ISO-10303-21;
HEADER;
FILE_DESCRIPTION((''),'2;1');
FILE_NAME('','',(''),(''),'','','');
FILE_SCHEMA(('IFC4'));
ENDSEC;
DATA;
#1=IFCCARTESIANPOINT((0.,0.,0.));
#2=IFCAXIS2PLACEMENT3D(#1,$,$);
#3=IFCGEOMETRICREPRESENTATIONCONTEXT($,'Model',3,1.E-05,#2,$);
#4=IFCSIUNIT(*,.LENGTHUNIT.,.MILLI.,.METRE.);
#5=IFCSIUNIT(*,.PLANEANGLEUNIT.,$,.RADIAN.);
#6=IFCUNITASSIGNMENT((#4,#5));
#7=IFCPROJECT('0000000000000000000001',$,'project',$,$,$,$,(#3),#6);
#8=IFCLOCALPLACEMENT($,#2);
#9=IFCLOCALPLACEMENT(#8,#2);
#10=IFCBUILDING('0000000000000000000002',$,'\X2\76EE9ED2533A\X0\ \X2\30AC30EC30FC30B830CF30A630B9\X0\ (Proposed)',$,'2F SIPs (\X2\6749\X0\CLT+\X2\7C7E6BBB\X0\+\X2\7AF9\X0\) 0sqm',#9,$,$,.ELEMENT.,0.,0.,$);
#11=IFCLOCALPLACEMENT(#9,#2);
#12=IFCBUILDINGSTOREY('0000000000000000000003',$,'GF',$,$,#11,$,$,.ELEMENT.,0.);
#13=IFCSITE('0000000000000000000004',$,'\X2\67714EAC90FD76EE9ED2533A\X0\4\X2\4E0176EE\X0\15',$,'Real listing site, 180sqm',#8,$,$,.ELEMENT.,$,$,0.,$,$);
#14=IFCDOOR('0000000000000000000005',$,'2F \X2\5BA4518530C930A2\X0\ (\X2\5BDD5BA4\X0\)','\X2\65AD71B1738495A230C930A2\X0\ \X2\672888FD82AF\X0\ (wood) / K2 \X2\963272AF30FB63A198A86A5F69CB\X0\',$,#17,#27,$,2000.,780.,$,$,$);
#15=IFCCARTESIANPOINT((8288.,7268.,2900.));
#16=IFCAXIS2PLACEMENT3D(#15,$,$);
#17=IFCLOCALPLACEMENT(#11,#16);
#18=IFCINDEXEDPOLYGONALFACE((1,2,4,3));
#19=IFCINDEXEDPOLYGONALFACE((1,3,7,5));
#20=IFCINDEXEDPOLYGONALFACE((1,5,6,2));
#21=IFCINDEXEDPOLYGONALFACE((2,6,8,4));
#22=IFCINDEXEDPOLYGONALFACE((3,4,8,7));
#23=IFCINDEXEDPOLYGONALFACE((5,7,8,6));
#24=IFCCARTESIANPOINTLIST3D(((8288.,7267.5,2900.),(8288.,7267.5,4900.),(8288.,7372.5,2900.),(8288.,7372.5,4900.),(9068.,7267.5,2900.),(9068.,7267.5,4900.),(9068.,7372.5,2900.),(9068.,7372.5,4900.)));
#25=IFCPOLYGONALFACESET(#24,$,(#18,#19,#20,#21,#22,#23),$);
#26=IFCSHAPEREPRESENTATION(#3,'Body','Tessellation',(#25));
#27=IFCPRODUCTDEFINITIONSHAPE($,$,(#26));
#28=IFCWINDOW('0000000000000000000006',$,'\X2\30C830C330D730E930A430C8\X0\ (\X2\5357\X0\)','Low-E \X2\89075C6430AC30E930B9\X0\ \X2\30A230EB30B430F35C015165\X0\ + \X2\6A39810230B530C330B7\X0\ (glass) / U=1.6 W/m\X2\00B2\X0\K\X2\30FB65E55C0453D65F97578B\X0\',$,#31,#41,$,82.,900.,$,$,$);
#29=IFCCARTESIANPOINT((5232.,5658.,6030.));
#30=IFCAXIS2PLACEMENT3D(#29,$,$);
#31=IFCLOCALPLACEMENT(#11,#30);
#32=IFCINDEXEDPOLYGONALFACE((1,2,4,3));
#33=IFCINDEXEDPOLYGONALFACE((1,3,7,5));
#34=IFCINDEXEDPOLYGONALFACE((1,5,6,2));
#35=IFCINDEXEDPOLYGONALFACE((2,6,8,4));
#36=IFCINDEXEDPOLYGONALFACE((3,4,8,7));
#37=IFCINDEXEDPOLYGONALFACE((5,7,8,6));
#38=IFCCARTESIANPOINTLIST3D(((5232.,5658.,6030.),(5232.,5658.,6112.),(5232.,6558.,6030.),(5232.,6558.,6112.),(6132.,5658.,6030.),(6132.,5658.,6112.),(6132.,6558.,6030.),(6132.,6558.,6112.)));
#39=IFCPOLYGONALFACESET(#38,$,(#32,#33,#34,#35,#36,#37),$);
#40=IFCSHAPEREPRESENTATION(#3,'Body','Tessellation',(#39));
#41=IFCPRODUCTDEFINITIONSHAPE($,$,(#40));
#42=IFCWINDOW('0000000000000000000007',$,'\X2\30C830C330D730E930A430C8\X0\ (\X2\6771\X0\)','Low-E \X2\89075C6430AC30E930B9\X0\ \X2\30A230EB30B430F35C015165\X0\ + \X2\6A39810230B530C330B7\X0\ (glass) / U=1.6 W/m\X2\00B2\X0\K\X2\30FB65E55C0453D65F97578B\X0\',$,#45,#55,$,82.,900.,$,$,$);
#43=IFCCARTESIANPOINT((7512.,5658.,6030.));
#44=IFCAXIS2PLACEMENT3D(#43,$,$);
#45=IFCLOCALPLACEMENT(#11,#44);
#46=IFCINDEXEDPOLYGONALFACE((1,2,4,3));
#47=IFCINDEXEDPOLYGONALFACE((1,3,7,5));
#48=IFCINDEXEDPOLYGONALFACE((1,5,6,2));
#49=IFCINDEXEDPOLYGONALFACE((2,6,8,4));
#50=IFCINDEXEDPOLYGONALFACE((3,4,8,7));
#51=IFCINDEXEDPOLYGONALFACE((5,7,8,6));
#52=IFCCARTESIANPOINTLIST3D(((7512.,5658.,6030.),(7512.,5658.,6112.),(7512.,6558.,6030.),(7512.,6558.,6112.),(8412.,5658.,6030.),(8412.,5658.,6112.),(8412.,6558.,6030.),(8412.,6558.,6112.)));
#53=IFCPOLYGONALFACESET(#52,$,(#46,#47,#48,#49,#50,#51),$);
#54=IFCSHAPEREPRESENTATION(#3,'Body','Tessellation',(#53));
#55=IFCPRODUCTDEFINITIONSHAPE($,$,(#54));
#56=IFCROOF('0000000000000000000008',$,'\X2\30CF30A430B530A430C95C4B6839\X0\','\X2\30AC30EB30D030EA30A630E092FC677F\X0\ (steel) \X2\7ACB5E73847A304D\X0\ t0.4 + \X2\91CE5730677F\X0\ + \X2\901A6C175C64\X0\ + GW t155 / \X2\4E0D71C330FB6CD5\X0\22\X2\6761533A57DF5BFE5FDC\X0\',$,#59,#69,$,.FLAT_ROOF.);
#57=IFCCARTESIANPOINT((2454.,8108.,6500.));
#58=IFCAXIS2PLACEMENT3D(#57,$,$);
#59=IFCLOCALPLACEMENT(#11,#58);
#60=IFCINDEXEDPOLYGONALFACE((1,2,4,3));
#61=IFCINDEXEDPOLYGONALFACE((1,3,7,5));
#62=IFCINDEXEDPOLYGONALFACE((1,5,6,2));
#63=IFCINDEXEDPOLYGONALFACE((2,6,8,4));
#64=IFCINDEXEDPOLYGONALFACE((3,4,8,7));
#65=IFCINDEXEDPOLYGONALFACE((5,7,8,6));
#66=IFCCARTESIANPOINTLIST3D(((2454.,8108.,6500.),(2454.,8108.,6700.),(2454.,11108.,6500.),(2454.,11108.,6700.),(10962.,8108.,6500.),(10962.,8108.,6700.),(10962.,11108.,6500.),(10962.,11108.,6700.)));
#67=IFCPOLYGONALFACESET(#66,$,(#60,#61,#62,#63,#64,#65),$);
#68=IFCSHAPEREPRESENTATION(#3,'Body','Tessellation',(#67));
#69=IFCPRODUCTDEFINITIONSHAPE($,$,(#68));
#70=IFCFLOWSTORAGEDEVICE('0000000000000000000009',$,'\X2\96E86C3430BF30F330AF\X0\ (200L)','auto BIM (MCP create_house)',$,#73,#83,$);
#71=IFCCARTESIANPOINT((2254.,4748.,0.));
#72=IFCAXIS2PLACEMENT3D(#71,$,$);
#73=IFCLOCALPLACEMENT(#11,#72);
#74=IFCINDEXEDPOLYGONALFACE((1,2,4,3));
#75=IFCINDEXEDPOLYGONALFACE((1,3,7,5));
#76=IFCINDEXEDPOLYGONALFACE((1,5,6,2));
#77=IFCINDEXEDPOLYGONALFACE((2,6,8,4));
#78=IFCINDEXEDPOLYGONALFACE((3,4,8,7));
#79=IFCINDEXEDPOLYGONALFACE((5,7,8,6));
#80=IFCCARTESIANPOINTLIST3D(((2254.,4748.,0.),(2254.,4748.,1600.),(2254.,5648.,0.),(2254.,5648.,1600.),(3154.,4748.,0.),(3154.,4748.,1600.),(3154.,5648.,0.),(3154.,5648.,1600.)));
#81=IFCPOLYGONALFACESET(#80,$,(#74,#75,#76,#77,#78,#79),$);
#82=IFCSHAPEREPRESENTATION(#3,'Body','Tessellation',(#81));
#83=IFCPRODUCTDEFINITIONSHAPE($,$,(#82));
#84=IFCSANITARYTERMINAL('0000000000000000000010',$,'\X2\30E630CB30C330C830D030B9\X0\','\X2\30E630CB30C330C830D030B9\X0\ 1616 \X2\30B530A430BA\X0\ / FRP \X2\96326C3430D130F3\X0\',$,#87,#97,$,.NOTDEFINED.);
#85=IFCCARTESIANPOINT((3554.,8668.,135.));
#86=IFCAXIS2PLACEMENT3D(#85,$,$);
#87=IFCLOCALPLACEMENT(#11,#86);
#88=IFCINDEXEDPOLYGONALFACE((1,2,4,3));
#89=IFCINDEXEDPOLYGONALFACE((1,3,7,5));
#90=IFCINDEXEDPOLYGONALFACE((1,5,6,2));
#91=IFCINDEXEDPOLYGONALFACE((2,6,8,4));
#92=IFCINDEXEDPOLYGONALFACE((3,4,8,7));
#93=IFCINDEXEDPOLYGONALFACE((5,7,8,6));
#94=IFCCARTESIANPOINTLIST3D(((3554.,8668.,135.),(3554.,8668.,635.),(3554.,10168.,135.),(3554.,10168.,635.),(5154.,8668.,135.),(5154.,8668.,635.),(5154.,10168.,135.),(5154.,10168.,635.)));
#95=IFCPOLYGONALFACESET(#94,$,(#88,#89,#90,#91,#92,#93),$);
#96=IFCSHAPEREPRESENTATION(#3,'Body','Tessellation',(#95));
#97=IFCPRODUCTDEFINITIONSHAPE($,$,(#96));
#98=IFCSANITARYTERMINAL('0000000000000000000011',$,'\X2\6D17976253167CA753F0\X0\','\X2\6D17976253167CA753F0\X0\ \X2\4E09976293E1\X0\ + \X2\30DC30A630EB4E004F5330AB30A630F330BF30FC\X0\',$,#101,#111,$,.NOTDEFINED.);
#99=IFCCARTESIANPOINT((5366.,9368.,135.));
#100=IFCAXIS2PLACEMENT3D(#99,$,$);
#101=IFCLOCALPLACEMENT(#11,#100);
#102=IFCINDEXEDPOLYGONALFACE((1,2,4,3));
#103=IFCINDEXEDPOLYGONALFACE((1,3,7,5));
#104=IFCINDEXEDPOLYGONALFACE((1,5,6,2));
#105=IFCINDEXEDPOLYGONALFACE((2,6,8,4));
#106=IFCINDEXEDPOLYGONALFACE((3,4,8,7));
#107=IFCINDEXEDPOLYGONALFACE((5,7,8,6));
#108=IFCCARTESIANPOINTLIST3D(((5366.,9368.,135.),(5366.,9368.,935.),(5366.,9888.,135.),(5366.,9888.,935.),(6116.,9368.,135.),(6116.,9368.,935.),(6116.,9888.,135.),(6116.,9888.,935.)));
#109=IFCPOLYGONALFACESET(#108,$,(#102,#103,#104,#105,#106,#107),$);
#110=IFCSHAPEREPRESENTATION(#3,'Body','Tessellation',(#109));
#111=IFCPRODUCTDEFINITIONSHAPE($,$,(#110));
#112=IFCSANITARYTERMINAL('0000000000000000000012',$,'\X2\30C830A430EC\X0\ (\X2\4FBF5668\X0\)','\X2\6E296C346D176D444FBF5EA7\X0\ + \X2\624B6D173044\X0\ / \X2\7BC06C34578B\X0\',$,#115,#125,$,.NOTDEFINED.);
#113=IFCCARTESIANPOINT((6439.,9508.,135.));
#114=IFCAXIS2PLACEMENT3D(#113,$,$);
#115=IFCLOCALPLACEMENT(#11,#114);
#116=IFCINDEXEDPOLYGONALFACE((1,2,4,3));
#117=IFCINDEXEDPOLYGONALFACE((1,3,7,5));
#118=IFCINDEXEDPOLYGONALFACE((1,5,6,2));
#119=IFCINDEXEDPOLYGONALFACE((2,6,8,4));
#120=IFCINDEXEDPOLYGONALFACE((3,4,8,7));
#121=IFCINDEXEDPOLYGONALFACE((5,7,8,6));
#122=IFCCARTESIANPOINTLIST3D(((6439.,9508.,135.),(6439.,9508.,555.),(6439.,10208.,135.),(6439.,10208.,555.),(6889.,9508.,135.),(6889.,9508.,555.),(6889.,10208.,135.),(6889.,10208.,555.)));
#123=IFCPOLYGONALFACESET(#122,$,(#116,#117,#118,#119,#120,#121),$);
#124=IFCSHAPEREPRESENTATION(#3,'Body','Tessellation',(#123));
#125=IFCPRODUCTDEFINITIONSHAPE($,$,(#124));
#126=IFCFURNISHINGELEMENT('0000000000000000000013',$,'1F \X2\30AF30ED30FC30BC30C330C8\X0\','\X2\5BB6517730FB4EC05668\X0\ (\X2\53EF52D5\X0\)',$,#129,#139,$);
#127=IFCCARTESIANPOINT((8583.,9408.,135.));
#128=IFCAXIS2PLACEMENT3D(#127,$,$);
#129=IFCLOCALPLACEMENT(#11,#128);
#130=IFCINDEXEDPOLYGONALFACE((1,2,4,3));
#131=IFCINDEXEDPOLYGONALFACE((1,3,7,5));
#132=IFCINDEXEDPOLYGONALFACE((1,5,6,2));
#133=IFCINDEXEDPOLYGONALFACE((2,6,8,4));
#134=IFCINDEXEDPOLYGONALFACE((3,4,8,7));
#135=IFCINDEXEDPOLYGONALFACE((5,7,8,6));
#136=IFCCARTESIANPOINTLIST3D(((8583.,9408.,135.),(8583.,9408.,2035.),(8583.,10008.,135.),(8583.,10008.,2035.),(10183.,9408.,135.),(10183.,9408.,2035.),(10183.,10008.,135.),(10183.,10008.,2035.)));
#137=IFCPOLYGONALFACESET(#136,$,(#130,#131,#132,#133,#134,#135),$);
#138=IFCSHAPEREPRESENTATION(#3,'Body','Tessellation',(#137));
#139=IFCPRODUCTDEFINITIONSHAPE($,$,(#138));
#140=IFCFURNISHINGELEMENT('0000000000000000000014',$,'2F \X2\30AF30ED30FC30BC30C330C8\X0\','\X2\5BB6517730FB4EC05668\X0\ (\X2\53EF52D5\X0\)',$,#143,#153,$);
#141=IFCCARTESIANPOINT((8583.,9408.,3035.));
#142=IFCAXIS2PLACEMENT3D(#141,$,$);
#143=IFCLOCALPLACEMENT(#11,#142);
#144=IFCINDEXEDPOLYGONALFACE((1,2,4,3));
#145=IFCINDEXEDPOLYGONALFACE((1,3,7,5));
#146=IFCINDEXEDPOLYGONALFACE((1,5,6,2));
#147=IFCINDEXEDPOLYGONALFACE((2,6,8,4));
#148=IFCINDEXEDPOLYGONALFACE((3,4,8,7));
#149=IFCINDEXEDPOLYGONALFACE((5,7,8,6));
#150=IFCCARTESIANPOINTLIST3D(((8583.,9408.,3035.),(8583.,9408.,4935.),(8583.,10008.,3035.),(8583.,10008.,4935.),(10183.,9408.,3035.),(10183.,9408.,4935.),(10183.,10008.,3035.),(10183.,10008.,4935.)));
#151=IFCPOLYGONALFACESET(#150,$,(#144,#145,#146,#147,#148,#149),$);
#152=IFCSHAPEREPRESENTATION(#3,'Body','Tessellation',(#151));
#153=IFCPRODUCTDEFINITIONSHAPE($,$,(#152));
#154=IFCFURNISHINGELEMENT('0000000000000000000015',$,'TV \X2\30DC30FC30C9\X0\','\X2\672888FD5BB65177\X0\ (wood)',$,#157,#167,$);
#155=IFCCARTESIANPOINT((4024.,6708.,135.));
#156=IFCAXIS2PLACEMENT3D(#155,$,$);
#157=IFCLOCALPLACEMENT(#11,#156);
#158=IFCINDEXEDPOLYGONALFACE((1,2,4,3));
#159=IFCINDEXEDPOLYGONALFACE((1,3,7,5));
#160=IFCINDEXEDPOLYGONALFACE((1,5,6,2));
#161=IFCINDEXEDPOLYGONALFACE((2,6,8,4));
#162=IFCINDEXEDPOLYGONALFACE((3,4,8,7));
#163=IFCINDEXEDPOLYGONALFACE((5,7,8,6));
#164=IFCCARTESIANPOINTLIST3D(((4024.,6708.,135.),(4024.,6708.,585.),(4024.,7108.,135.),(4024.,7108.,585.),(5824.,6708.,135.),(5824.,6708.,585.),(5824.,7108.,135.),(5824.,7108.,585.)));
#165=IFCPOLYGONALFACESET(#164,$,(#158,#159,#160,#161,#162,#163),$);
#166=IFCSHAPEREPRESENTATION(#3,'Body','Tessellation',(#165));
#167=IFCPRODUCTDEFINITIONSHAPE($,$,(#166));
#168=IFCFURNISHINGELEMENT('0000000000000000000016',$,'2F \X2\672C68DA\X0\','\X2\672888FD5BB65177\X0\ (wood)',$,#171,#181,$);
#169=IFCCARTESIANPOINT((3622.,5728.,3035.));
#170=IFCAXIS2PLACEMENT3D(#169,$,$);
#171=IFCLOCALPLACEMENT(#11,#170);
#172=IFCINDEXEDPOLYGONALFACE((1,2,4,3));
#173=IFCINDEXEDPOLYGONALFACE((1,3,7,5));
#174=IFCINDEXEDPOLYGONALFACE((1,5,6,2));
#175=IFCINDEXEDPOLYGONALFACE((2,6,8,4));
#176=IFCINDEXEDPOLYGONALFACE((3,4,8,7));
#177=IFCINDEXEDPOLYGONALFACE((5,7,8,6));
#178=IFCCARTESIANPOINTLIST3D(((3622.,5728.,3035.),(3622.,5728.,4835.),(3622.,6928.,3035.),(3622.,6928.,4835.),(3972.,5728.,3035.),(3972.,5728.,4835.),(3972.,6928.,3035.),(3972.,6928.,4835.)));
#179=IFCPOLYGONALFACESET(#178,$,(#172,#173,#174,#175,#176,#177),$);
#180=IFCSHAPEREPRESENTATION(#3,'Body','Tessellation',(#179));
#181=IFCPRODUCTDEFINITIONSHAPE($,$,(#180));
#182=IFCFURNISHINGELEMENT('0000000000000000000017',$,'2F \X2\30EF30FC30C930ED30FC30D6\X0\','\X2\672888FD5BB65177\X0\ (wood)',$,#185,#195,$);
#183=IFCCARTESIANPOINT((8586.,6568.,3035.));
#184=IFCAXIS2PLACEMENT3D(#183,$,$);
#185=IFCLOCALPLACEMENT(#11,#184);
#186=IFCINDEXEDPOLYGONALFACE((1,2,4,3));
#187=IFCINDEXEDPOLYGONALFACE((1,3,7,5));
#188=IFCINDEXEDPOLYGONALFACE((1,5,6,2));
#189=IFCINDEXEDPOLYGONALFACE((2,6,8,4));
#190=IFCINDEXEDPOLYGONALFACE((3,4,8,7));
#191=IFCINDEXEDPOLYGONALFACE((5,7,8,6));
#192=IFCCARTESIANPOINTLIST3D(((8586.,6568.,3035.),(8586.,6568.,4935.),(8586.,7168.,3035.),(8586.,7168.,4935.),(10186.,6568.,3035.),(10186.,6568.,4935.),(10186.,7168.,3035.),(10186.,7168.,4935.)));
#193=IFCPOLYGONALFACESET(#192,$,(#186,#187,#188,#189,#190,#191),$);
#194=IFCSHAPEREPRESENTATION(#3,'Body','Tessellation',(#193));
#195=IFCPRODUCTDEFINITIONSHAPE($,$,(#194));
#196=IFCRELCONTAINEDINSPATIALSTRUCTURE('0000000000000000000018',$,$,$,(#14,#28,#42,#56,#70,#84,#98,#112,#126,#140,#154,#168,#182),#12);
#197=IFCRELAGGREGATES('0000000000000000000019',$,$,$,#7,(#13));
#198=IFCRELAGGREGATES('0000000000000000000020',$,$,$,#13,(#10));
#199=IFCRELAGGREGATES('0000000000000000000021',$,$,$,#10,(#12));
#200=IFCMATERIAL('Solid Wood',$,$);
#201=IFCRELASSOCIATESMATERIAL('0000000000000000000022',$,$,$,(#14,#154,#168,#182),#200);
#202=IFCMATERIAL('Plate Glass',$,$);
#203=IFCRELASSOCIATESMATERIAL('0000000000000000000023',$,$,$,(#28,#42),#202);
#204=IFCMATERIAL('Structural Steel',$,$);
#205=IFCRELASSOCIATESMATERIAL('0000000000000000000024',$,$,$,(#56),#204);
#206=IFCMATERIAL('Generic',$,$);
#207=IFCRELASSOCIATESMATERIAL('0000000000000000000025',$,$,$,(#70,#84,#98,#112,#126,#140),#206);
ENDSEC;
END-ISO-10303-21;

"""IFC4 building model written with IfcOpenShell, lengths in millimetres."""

from ifc_helpers import new_model, si_unit, frame, frame_2d, origin, place, context, project, spatial, rectangle, extrude, material, element, save


model = new_model("IFC4")

# Units and contexts
model_context = context("Model", 3, precision=1e-05, world=origin())
ifc_project = project(units=[si_unit("LENGTHUNIT", "METRE", prefix="MILLI"), si_unit("PLANEANGLEUNIT", "RADIAN")], contexts=[model_context])

# Site, building, storey
site_placement = place(None, origin())
site = spatial("IfcSite", under=ifc_project, at=site_placement, Name="東京都目黒区4丁目15", ObjectType="Real listing site, 180sqm", CompositionType="ELEMENT", RefElevation=0.0)
building_placement = place(site_placement, origin())
building = spatial("IfcBuilding", under=site, at=building_placement, Name="目黒区 ガレージハウス (Proposed)", ObjectType="2F SIPs (杉CLT+籾殻+竹) 0sqm", CompositionType="ELEMENT", ElevationOfRefHeight=0.0, ElevationOfTerrain=0.0)
storey_placement = place(building_placement, origin())
storey = spatial("IfcBuildingStorey", under=building, at=storey_placement, Name="GF", CompositionType="ELEMENT", Elevation=0.0)

# Shared definitions
ifc_material_1 = material(Name="Solid Wood")
ifc_material_2 = material(Name="Plate Glass")

# Door
door_1_placement = place(storey_placement, frame((8288.0, 7268.0, 2900.0)))
element("IfcDoor", 1, at=door_1_placement, inside=storey, material=ifc_material_1, Name="2F 室内ドア (寝室)", Description="断熱玄関ドア 木製芯 (wood) / K2 防犯・採風機構", OverallHeight=2000.0, OverallWidth=780.0, context=model_context, shape_type="SweptSolid", body=[
    extrude(rectangle(XDim=780.0, YDim=105.0, at=frame_2d((390.0, 52.0))), frame((8288.0, 7268.0, 2900.0)), (0.0, 0.0, 1.0), 2000.0),
])

# Windows
window_1_placement = place(storey_placement, frame((5232.0, 5658.0, 6030.0)))
element("IfcWindow", 2, at=window_1_placement, inside=storey, material=ifc_material_2, Name="トップライト (南)", Description="Low-E 複層ガラス アルゴン封入 + 樹脂サッシ (glass) / U=1.6 W/m²K・日射取得型", OverallHeight=82.0, OverallWidth=900.0, context=model_context, shape_type="SweptSolid", body=[
    extrude(rectangle(XDim=900.0, YDim=900.0, at=frame_2d((450.0, 450.0))), frame((5232.0, 5658.0, 6030.0)), (0.0, 0.0, 1.0), 82.0),
])
window_2_placement = place(storey_placement, frame((7512.0, 5658.0, 6030.0)))
element("IfcWindow", 3, at=window_2_placement, inside=storey, material=ifc_material_2, Name="トップライト (東)", Description="Low-E 複層ガラス アルゴン封入 + 樹脂サッシ (glass) / U=1.6 W/m²K・日射取得型", OverallHeight=82.0, OverallWidth=900.0, context=model_context, shape_type="SweptSolid", body=[
    extrude(rectangle(XDim=900.0, YDim=900.0, at=frame_2d((450.0, 450.0))), frame((7512.0, 5658.0, 6030.0)), (0.0, 0.0, 1.0), 82.0),
])

# Roof
ifc_material_3 = material(Name="Structural Steel")
roof_placement = place(storey_placement, frame((2454.0, 8108.0, 6500.0)))
element("IfcRoof", 4, at=roof_placement, inside=storey, material=ifc_material_3, Name="ハイサイド屋根", Description="ガルバリウム鋼板 (steel) 立平葺き t0.4 + 野地板 + 通気層 + GW t155 / 不燃・法22条区域対応", PredefinedType="FLAT_ROOF", context=model_context, shape_type="SweptSolid", body=[
    extrude(rectangle(XDim=8508.0, YDim=3000.0, at=frame_2d((4254.0, 1500.0))), frame((2454.0, 8108.0, 6500.0)), (0.0, 0.0, 1.0), 200.0),
])

# Flow storage device
ifc_material_4 = material(Name="Generic")
flow_storage_device_placement = place(storey_placement, frame((2254.0, 4748.0, 0.0)))
element("IfcFlowStorageDevice", 5, at=flow_storage_device_placement, inside=storey, material=ifc_material_4, Name="雨水タンク (200L)", Description="auto BIM (MCP create_house)", context=model_context, shape_type="SweptSolid", body=[
    extrude(rectangle(XDim=900.0, YDim=900.0, at=frame_2d((450.0, 450.0))), frame((2254.0, 4748.0, 0.0)), (0.0, 0.0, 1.0), 1600.0),
])

# Sanitary terminals
sanitary_terminal_1_placement = place(storey_placement, frame((3554.0, 8668.0, 135.0)))
element("IfcSanitaryTerminal", 6, at=sanitary_terminal_1_placement, inside=storey, material=ifc_material_4, Name="ユニットバス", Description="ユニットバス 1616 サイズ / FRP 防水パン", PredefinedType="NOTDEFINED", context=model_context, shape_type="SweptSolid", body=[
    extrude(rectangle(XDim=1600.0, YDim=1500.0, at=frame_2d((800.0, 750.0))), frame((3554.0, 8668.0, 135.0)), (0.0, 0.0, 1.0), 500.0),
])
sanitary_terminal_2_placement = place(storey_placement, frame((5366.0, 9368.0, 135.0)))
element("IfcSanitaryTerminal", 7, at=sanitary_terminal_2_placement, inside=storey, material=ifc_material_4, Name="洗面化粧台", Description="洗面化粧台 三面鏡 + ボウル一体カウンター", PredefinedType="NOTDEFINED", context=model_context, shape_type="SweptSolid", body=[
    extrude(rectangle(XDim=750.0, YDim=520.0, at=frame_2d((375.0, 260.0))), frame((5366.0, 9368.0, 135.0)), (0.0, 0.0, 1.0), 800.0),
])
sanitary_terminal_3_placement = place(storey_placement, frame((6439.0, 9508.0, 135.0)))
element("IfcSanitaryTerminal", 8, at=sanitary_terminal_3_placement, inside=storey, material=ifc_material_4, Name="トイレ (便器)", Description="温水洗浄便座 + 手洗い / 節水型", PredefinedType="NOTDEFINED", context=model_context, shape_type="SweptSolid", body=[
    extrude(rectangle(XDim=450.0, YDim=700.0, at=frame_2d((225.0, 350.0))), frame((6439.0, 9508.0, 135.0)), (0.0, 0.0, 1.0), 420.0),
])

# Furnishing elements
furnishing_1_placement = place(storey_placement, frame((8583.0, 9408.0, 135.0)))
element("IfcFurnishingElement", 9, at=furnishing_1_placement, inside=storey, material=ifc_material_4, Name="1F クローゼット", Description="家具・什器 (可動)", context=model_context, shape_type="SweptSolid", body=[
    extrude(rectangle(XDim=1600.0, YDim=600.0, at=frame_2d((800.0, 300.0))), frame((8583.0, 9408.0, 135.0)), (0.0, 0.0, 1.0), 1900.0),
])
furnishing_2_placement = place(storey_placement, frame((8583.0, 9408.0, 3035.0)))
element("IfcFurnishingElement", 10, at=furnishing_2_placement, inside=storey, material=ifc_material_4, Name="2F クローゼット", Description="家具・什器 (可動)", context=model_context, shape_type="SweptSolid", body=[
    extrude(rectangle(XDim=1600.0, YDim=600.0, at=frame_2d((800.0, 300.0))), frame((8583.0, 9408.0, 3035.0)), (0.0, 0.0, 1.0), 1900.0),
])
furnishing_3_placement = place(storey_placement, frame((4024.0, 6708.0, 135.0)))
element("IfcFurnishingElement", 11, at=furnishing_3_placement, inside=storey, material=ifc_material_1, Name="TV ボード", Description="木製家具 (wood)", context=model_context, shape_type="SweptSolid", body=[
    extrude(rectangle(XDim=1800.0, YDim=400.0, at=frame_2d((900.0, 200.0))), frame((4024.0, 6708.0, 135.0)), (0.0, 0.0, 1.0), 450.0),
])
furnishing_4_placement = place(storey_placement, frame((3622.0, 5728.0, 3035.0)))
element("IfcFurnishingElement", 12, at=furnishing_4_placement, inside=storey, material=ifc_material_1, Name="2F 本棚", Description="木製家具 (wood)", context=model_context, shape_type="SweptSolid", body=[
    extrude(rectangle(XDim=350.0, YDim=1200.0, at=frame_2d((175.0, 600.0))), frame((3622.0, 5728.0, 3035.0)), (0.0, 0.0, 1.0), 1800.0),
])
furnishing_5_placement = place(storey_placement, frame((8586.0, 6568.0, 3035.0)))
element("IfcFurnishingElement", 13, at=furnishing_5_placement, inside=storey, material=ifc_material_1, Name="2F ワードローブ", Description="木製家具 (wood)", context=model_context, shape_type="SweptSolid", body=[
    extrude(rectangle(XDim=1600.0, YDim=600.0, at=frame_2d((800.0, 300.0))), frame((8586.0, 6568.0, 3035.0)), (0.0, 0.0, 1.0), 1900.0),
])

save(model, "model.ifc")
